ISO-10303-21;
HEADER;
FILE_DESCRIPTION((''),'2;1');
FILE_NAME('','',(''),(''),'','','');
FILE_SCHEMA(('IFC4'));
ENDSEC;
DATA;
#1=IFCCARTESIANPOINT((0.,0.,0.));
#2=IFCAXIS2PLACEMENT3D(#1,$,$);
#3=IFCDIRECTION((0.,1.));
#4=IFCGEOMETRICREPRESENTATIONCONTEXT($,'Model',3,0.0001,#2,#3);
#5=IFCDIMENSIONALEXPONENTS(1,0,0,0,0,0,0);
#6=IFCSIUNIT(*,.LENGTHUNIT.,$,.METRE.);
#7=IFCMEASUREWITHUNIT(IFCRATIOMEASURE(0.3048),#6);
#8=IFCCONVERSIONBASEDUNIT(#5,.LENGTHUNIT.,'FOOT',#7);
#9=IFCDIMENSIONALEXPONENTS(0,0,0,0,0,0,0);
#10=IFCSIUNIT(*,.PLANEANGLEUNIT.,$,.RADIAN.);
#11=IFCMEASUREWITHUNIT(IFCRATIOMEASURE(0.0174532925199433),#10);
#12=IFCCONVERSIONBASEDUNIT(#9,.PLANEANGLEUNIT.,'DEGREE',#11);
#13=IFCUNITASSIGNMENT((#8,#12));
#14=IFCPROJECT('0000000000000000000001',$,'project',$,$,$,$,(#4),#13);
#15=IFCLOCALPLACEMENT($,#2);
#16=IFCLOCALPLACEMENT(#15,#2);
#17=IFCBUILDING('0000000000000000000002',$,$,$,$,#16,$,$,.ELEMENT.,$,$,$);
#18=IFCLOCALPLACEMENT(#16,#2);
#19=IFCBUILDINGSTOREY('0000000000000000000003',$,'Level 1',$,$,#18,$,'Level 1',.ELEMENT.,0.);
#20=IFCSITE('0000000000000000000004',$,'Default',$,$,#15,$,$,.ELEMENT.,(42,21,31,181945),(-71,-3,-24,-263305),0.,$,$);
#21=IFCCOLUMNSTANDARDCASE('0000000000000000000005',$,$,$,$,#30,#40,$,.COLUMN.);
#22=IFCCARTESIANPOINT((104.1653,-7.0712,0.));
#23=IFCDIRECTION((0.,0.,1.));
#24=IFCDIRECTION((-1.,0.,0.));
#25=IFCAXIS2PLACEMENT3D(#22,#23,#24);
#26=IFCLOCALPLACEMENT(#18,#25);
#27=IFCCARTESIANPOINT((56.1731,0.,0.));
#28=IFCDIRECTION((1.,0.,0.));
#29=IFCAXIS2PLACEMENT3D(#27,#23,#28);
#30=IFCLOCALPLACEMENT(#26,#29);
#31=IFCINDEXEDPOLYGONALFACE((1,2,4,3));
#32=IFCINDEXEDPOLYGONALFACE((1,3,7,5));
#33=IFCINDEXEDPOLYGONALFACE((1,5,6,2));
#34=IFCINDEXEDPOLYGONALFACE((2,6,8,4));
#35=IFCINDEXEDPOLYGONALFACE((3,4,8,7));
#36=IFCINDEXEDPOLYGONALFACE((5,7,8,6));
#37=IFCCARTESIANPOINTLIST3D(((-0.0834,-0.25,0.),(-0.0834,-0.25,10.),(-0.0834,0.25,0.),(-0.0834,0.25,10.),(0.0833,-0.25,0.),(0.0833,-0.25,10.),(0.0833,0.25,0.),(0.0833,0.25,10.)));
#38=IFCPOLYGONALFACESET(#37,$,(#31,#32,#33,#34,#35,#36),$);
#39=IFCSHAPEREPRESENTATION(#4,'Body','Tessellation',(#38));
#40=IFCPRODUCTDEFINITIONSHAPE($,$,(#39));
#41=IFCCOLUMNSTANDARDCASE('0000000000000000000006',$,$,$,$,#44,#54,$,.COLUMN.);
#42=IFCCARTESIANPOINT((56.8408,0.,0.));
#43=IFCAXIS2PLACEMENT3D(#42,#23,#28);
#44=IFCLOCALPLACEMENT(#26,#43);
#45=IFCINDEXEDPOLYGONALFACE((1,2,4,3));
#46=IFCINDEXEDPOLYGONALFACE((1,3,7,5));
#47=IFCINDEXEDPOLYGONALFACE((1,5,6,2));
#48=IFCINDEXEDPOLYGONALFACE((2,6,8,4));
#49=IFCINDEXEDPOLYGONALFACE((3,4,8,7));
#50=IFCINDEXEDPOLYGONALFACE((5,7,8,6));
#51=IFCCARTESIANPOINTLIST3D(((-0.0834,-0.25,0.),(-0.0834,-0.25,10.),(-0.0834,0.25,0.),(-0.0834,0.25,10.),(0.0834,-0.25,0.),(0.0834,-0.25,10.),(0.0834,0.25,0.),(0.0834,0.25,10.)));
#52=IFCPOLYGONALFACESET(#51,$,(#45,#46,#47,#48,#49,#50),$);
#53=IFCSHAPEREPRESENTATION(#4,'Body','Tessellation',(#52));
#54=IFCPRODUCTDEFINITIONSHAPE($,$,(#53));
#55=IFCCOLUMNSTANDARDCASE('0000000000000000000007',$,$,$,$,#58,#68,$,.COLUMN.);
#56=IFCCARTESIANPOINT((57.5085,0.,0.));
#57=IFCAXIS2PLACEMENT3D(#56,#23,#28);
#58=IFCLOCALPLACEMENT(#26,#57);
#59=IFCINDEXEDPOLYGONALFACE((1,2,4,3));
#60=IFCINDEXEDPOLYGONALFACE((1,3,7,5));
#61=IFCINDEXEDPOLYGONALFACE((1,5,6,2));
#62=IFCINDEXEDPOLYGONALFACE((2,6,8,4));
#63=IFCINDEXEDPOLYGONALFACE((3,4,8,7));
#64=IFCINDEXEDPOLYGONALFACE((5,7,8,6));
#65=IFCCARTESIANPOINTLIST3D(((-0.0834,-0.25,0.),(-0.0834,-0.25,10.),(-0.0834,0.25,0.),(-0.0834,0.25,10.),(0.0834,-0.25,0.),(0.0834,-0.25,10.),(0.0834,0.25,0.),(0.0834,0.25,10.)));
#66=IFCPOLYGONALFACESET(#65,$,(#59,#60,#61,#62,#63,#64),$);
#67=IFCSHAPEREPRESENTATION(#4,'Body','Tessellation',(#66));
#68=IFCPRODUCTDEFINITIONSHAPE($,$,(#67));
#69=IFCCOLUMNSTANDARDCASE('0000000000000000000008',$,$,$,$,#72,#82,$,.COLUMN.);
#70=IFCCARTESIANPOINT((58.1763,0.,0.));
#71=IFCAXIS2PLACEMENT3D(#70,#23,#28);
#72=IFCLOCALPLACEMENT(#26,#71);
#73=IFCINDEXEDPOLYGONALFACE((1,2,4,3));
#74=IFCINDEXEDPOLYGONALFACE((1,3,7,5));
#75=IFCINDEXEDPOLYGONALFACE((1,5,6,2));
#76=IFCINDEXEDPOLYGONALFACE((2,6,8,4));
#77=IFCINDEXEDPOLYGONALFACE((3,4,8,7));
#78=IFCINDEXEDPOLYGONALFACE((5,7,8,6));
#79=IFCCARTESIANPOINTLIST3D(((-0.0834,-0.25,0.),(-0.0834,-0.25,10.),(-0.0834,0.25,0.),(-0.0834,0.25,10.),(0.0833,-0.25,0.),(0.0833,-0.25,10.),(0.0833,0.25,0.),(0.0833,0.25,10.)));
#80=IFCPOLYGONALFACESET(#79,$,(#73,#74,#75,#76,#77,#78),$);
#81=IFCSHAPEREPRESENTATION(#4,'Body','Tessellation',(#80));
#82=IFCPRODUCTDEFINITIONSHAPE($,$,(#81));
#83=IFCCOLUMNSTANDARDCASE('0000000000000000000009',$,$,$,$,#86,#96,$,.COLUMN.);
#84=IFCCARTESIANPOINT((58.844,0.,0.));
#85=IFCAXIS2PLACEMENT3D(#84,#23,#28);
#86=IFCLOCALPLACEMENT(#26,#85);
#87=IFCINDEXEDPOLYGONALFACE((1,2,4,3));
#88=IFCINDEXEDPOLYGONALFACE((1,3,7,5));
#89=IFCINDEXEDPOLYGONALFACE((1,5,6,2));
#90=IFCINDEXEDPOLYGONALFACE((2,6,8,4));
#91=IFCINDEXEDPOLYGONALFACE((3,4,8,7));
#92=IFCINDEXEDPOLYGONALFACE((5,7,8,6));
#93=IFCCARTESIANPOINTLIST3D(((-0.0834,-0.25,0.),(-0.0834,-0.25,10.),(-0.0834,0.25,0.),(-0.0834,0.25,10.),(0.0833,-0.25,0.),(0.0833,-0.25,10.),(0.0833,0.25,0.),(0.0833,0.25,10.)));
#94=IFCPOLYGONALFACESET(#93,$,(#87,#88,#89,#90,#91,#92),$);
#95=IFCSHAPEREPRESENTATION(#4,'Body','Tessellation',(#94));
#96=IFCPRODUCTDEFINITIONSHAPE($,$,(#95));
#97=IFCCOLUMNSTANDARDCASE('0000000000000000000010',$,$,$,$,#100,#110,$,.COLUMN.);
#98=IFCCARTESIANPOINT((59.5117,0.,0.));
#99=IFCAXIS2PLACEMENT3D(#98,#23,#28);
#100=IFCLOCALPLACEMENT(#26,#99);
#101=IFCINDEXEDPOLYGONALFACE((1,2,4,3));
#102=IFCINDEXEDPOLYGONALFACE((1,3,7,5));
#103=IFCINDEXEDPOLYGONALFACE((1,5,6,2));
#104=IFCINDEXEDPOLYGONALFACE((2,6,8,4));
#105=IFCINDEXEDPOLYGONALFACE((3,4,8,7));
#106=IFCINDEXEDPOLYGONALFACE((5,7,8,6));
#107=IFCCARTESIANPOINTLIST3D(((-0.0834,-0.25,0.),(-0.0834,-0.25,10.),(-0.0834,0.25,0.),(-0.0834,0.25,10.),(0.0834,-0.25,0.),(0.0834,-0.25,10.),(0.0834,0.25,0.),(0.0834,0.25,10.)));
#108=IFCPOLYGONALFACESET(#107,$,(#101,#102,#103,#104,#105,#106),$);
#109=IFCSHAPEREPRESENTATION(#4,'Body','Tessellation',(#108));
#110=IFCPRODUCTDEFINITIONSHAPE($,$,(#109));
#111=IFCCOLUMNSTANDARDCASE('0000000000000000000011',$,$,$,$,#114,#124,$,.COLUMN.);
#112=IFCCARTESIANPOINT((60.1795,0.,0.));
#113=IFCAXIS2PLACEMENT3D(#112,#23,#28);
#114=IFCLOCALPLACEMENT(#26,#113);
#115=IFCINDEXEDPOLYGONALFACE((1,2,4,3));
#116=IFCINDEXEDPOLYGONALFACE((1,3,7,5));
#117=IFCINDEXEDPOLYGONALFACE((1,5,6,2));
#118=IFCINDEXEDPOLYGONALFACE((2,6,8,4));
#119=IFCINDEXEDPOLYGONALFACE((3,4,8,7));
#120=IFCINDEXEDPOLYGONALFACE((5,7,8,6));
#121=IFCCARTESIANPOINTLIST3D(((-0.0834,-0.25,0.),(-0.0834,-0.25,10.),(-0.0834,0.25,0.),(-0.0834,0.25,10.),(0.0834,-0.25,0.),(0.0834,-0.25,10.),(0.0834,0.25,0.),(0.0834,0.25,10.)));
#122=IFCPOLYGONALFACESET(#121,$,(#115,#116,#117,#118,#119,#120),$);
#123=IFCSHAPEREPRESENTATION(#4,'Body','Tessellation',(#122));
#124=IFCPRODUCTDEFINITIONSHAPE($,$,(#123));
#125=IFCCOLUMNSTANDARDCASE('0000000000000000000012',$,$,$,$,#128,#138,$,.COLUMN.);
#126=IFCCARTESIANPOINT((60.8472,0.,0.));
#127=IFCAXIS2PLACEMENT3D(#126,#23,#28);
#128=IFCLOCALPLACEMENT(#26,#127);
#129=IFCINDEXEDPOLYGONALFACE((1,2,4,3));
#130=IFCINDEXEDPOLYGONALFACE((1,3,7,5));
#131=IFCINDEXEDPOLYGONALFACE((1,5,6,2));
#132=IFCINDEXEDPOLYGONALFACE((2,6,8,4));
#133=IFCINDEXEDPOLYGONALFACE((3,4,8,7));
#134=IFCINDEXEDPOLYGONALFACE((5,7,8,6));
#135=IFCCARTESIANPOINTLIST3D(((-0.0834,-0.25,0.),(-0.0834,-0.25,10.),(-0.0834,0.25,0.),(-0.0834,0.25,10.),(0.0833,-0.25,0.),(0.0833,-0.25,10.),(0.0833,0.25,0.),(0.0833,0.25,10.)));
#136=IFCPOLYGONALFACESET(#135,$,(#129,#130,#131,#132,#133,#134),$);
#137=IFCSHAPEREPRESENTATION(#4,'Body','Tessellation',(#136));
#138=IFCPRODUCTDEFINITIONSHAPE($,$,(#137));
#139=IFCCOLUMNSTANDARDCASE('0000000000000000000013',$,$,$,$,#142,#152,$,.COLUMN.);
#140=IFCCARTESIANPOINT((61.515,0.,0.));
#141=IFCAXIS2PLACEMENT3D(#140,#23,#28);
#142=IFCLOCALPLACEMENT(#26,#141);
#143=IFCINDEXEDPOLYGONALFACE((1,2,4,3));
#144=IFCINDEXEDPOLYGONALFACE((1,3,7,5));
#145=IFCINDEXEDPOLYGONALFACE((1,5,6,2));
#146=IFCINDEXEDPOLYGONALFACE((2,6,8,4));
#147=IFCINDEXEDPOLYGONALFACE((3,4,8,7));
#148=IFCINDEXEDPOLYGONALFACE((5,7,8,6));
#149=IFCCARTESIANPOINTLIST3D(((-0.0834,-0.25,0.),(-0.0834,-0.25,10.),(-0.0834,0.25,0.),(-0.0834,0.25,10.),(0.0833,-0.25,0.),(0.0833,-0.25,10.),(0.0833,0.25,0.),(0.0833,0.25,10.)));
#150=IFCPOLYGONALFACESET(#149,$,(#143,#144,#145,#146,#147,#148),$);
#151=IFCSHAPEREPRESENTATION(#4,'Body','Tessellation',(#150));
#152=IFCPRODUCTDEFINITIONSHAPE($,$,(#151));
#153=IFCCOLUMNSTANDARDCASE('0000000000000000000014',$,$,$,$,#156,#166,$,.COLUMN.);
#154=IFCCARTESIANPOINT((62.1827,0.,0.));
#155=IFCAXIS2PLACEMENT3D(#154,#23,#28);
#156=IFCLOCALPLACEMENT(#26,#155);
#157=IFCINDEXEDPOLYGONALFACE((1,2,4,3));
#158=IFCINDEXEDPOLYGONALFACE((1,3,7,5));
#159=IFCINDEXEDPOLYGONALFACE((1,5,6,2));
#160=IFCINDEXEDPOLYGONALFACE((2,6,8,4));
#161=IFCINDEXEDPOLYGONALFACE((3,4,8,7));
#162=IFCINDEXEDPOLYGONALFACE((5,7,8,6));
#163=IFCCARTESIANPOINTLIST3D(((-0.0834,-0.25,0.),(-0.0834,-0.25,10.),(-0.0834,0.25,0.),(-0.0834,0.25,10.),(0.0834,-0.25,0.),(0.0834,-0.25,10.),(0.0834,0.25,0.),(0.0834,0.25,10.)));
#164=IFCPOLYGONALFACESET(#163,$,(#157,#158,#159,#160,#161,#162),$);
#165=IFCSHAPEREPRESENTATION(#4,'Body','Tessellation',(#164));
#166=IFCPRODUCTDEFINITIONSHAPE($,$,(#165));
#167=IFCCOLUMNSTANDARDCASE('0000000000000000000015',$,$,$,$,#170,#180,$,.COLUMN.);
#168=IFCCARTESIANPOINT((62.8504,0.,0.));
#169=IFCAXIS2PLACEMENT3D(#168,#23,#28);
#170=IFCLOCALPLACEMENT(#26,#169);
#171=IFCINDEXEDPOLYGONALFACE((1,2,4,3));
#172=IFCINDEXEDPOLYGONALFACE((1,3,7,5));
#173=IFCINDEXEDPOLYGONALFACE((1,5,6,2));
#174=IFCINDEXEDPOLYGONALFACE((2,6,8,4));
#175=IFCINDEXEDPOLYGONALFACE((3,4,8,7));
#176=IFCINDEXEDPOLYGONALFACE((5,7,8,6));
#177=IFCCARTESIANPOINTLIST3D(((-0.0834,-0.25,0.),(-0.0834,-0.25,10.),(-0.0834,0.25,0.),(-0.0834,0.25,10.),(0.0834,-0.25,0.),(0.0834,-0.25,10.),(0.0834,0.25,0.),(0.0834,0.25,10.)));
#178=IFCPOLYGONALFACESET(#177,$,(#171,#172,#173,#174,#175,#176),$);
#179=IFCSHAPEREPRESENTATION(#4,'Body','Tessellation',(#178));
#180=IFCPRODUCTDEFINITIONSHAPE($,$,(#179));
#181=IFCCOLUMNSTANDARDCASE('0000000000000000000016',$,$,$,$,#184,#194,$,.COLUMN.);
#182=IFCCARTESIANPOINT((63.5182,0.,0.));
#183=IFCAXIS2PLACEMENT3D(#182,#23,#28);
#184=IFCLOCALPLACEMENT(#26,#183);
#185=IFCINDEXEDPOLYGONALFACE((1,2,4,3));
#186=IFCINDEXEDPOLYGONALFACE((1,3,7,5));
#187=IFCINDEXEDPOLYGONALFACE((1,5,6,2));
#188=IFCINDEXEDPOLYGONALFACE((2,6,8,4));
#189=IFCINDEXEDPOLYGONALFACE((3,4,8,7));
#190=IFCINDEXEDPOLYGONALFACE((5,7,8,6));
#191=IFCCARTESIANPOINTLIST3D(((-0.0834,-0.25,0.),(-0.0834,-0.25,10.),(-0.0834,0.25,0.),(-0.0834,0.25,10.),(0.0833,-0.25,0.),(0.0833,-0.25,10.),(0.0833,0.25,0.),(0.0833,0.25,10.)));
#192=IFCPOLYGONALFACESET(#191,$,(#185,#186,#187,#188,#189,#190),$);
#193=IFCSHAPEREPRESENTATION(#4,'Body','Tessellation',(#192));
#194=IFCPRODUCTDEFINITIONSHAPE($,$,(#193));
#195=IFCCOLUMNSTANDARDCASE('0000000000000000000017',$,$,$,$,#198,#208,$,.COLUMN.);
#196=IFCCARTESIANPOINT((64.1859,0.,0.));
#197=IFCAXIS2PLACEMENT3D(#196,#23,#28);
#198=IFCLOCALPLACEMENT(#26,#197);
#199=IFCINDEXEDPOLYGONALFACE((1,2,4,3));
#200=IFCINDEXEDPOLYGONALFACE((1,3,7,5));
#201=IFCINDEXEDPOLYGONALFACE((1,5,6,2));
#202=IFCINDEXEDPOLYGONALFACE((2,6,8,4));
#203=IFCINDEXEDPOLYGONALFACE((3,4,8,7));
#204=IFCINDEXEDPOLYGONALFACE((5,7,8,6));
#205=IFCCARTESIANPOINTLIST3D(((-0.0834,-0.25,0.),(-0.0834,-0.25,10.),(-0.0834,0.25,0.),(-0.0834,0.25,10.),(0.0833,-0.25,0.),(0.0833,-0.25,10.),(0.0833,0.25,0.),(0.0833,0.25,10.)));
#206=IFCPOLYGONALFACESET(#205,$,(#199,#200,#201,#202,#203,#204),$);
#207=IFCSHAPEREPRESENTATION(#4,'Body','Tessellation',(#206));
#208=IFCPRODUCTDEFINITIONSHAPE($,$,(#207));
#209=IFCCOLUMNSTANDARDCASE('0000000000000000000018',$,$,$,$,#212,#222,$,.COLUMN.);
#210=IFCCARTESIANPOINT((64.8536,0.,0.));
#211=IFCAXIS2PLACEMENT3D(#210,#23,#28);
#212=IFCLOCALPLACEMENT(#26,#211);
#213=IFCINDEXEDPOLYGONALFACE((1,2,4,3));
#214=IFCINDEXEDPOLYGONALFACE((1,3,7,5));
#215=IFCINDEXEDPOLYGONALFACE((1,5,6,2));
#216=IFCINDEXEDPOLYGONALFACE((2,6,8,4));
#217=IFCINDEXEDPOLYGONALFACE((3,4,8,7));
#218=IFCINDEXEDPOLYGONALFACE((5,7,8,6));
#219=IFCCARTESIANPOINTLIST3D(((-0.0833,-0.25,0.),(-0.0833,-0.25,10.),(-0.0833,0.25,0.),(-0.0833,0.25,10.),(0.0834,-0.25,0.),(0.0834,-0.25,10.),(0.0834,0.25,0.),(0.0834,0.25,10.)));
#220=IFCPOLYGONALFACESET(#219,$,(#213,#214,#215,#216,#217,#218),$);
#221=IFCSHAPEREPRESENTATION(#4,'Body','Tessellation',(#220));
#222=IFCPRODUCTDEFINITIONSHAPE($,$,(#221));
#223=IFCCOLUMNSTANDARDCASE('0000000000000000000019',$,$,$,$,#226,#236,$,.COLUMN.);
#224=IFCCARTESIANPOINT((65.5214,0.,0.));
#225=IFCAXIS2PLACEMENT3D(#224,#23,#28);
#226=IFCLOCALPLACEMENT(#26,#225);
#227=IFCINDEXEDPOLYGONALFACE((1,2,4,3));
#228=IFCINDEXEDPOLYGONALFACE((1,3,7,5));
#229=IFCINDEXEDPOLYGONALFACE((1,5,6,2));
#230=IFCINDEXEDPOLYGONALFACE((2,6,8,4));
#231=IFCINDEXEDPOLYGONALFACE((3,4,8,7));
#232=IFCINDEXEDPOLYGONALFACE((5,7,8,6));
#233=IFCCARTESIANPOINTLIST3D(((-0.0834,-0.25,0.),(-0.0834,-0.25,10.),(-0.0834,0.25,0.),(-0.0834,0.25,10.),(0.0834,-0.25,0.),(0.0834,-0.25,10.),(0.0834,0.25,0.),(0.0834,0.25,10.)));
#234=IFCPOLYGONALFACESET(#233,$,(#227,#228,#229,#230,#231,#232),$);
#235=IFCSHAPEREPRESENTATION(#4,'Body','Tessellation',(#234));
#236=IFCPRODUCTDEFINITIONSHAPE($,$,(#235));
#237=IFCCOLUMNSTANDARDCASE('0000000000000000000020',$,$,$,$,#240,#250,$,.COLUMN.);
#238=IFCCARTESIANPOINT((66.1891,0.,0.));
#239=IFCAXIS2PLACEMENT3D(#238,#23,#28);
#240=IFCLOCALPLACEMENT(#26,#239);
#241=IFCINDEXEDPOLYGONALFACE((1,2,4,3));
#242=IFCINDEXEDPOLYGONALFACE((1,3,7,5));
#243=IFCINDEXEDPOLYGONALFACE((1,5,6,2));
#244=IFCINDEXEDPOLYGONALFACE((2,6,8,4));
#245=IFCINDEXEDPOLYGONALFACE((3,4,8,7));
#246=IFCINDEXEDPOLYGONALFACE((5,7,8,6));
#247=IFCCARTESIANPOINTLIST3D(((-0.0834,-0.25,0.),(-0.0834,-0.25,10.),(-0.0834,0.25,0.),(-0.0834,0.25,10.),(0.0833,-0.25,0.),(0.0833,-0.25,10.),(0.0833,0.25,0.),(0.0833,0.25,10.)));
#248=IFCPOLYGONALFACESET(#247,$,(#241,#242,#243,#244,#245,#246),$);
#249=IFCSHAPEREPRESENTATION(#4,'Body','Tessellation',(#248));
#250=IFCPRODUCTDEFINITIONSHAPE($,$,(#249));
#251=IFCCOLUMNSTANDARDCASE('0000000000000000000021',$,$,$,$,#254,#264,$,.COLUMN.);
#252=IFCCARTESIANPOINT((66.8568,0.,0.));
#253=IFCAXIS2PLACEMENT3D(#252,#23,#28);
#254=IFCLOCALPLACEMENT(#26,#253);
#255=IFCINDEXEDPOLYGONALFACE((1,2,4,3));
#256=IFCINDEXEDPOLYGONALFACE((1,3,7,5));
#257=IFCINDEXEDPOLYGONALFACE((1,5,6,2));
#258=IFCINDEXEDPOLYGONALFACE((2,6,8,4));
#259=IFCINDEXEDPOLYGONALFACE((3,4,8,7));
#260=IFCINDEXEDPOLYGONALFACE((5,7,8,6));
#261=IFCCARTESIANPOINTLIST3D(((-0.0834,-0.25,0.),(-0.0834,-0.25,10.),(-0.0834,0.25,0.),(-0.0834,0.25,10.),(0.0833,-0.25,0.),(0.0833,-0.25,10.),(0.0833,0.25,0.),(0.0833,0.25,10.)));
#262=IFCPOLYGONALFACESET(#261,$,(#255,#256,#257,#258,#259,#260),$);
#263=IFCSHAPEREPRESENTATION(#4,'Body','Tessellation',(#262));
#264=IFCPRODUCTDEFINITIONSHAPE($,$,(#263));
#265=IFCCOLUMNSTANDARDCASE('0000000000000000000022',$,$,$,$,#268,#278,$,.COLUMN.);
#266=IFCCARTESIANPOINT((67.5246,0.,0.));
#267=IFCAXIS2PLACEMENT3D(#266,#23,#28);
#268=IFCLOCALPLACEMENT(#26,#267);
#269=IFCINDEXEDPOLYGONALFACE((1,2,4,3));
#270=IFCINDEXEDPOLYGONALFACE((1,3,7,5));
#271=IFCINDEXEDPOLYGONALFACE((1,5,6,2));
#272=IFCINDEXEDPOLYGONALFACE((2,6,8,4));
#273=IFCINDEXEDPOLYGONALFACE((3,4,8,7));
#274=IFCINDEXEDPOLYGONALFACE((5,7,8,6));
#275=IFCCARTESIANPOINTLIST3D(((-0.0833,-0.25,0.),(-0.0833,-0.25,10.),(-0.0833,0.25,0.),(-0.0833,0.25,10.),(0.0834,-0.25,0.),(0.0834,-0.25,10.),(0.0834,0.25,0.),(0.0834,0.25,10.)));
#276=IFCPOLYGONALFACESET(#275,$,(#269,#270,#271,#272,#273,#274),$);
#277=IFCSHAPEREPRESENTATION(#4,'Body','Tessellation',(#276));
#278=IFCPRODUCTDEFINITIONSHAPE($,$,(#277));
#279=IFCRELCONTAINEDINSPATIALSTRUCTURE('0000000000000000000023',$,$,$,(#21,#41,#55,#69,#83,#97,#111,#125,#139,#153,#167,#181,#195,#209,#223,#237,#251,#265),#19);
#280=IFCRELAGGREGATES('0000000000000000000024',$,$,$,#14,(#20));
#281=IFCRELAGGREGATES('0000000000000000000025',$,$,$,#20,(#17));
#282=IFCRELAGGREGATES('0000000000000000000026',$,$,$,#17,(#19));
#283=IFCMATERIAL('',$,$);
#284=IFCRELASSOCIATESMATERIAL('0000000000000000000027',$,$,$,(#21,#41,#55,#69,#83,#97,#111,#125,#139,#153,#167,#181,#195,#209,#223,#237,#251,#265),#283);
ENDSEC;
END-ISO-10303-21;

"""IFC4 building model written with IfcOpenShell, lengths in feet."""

from ifc_helpers import new_model, entity, si_unit, converted_unit, direction, frame, origin, place, context, project, spatial, rectangle, extrude, material, element, save


model = new_model("IFC4")

# Units and contexts
model_context = context("Model", 3, precision=0.0001, world=origin(), true_north=direction((0.0, 1.0)))
ifc_project = project(units=[converted_unit("LENGTHUNIT", "FOOT", entity("IfcRatioMeasure", 0.3048), si_unit("LENGTHUNIT", "METRE"), dimensions=[1, 0, 0, 0, 0, 0, 0]), converted_unit("PLANEANGLEUNIT", "DEGREE", entity("IfcRatioMeasure", 0.0174532925199433), si_unit("PLANEANGLEUNIT", "RADIAN"), dimensions=[0, 0, 0, 0, 0, 0, 0])], contexts=[model_context])

# Site, building, storey
site_placement = place(None, origin())
site = spatial("IfcSite", under=ifc_project, at=site_placement, Name="Default", CompositionType="ELEMENT", RefLatitude=(42, 21, 31, 181945), RefLongitude=(-71, -3, -24, -263305), RefElevation=0.0)
building_placement = place(site_placement, origin())
building = spatial("IfcBuilding", under=site, at=building_placement, CompositionType="ELEMENT")
storey_placement = place(building_placement, origin())
storey = spatial("IfcBuildingStorey", under=building, at=storey_placement, Name="Level 1", LongName="Level 1", CompositionType="ELEMENT", Elevation=0.0)

# Columns
ifc_material_1 = material(Name="")
placement_1 = place(storey_placement, frame((104.1653, -7.0712, 0.0), z_axis=(0.0, 0.0, 1.0), x_axis=(-1.0, 0.0, 0.0)))
for number, where, z_axis, x_axis in (
    (1, (56.1731, 0.0, 0.0), (0.0, 0.0, 1.0), (1.0, 0.0, 0.0)),
    (2, (56.8408, 0.0, 0.0), (0.0, 0.0, 1.0), (1.0, 0.0, 0.0)),
    (3, (57.5085, 0.0, 0.0), (0.0, 0.0, 1.0), (1.0, 0.0, 0.0)),
    (4, (58.1763, 0.0, 0.0), (0.0, 0.0, 1.0), (1.0, 0.0, 0.0)),
    (5, (58.844, 0.0, 0.0), (0.0, 0.0, 1.0), (1.0, 0.0, 0.0)),
    (6, (59.5117, 0.0, 0.0), (0.0, 0.0, 1.0), (1.0, 0.0, 0.0)),
    (7, (60.1795, 0.0, 0.0), (0.0, 0.0, 1.0), (1.0, 0.0, 0.0)),
    (8, (60.8472, 0.0, 0.0), (0.0, 0.0, 1.0), (1.0, 0.0, 0.0)),
    (9, (61.515, 0.0, 0.0), (0.0, 0.0, 1.0), (1.0, 0.0, 0.0)),
    (10, (62.1827, 0.0, 0.0), (0.0, 0.0, 1.0), (1.0, 0.0, 0.0)),
    (11, (62.8504, 0.0, 0.0), (0.0, 0.0, 1.0), (1.0, 0.0, 0.0)),
    (12, (63.5182, 0.0, 0.0), (0.0, 0.0, 1.0), (1.0, 0.0, 0.0)),
    (13, (64.1859, 0.0, 0.0), (0.0, 0.0, 1.0), (1.0, 0.0, 0.0)),
    (14, (64.8536, 0.0, 0.0), (0.0, 0.0, 1.0), (1.0, 0.0, 0.0)),
    (15, (65.5214, 0.0, 0.0), (0.0, 0.0, 1.0), (1.0, 0.0, 0.0)),
    (16, (66.1891, 0.0, 0.0), (0.0, 0.0, 1.0), (1.0, 0.0, 0.0)),
    (17, (66.8568, 0.0, 0.0), (0.0, 0.0, 1.0), (1.0, 0.0, 0.0)),
    (18, (67.5246, 0.0, 0.0), (0.0, 0.0, 1.0), (1.0, 0.0, 0.0)),
):
    element("IfcColumnStandardCase", number, at=place(placement_1, frame(where, z_axis=z_axis, x_axis=x_axis)), inside=storey, material=ifc_material_1, PredefinedType="COLUMN", context=model_context, shape_type="SweptSolid", body=[
        extrude(rectangle(XDim=0.1667, YDim=0.5), origin(), (0.0, 0.0, 1.0), 10.0),
    ])

save(model, "model.ifc")
